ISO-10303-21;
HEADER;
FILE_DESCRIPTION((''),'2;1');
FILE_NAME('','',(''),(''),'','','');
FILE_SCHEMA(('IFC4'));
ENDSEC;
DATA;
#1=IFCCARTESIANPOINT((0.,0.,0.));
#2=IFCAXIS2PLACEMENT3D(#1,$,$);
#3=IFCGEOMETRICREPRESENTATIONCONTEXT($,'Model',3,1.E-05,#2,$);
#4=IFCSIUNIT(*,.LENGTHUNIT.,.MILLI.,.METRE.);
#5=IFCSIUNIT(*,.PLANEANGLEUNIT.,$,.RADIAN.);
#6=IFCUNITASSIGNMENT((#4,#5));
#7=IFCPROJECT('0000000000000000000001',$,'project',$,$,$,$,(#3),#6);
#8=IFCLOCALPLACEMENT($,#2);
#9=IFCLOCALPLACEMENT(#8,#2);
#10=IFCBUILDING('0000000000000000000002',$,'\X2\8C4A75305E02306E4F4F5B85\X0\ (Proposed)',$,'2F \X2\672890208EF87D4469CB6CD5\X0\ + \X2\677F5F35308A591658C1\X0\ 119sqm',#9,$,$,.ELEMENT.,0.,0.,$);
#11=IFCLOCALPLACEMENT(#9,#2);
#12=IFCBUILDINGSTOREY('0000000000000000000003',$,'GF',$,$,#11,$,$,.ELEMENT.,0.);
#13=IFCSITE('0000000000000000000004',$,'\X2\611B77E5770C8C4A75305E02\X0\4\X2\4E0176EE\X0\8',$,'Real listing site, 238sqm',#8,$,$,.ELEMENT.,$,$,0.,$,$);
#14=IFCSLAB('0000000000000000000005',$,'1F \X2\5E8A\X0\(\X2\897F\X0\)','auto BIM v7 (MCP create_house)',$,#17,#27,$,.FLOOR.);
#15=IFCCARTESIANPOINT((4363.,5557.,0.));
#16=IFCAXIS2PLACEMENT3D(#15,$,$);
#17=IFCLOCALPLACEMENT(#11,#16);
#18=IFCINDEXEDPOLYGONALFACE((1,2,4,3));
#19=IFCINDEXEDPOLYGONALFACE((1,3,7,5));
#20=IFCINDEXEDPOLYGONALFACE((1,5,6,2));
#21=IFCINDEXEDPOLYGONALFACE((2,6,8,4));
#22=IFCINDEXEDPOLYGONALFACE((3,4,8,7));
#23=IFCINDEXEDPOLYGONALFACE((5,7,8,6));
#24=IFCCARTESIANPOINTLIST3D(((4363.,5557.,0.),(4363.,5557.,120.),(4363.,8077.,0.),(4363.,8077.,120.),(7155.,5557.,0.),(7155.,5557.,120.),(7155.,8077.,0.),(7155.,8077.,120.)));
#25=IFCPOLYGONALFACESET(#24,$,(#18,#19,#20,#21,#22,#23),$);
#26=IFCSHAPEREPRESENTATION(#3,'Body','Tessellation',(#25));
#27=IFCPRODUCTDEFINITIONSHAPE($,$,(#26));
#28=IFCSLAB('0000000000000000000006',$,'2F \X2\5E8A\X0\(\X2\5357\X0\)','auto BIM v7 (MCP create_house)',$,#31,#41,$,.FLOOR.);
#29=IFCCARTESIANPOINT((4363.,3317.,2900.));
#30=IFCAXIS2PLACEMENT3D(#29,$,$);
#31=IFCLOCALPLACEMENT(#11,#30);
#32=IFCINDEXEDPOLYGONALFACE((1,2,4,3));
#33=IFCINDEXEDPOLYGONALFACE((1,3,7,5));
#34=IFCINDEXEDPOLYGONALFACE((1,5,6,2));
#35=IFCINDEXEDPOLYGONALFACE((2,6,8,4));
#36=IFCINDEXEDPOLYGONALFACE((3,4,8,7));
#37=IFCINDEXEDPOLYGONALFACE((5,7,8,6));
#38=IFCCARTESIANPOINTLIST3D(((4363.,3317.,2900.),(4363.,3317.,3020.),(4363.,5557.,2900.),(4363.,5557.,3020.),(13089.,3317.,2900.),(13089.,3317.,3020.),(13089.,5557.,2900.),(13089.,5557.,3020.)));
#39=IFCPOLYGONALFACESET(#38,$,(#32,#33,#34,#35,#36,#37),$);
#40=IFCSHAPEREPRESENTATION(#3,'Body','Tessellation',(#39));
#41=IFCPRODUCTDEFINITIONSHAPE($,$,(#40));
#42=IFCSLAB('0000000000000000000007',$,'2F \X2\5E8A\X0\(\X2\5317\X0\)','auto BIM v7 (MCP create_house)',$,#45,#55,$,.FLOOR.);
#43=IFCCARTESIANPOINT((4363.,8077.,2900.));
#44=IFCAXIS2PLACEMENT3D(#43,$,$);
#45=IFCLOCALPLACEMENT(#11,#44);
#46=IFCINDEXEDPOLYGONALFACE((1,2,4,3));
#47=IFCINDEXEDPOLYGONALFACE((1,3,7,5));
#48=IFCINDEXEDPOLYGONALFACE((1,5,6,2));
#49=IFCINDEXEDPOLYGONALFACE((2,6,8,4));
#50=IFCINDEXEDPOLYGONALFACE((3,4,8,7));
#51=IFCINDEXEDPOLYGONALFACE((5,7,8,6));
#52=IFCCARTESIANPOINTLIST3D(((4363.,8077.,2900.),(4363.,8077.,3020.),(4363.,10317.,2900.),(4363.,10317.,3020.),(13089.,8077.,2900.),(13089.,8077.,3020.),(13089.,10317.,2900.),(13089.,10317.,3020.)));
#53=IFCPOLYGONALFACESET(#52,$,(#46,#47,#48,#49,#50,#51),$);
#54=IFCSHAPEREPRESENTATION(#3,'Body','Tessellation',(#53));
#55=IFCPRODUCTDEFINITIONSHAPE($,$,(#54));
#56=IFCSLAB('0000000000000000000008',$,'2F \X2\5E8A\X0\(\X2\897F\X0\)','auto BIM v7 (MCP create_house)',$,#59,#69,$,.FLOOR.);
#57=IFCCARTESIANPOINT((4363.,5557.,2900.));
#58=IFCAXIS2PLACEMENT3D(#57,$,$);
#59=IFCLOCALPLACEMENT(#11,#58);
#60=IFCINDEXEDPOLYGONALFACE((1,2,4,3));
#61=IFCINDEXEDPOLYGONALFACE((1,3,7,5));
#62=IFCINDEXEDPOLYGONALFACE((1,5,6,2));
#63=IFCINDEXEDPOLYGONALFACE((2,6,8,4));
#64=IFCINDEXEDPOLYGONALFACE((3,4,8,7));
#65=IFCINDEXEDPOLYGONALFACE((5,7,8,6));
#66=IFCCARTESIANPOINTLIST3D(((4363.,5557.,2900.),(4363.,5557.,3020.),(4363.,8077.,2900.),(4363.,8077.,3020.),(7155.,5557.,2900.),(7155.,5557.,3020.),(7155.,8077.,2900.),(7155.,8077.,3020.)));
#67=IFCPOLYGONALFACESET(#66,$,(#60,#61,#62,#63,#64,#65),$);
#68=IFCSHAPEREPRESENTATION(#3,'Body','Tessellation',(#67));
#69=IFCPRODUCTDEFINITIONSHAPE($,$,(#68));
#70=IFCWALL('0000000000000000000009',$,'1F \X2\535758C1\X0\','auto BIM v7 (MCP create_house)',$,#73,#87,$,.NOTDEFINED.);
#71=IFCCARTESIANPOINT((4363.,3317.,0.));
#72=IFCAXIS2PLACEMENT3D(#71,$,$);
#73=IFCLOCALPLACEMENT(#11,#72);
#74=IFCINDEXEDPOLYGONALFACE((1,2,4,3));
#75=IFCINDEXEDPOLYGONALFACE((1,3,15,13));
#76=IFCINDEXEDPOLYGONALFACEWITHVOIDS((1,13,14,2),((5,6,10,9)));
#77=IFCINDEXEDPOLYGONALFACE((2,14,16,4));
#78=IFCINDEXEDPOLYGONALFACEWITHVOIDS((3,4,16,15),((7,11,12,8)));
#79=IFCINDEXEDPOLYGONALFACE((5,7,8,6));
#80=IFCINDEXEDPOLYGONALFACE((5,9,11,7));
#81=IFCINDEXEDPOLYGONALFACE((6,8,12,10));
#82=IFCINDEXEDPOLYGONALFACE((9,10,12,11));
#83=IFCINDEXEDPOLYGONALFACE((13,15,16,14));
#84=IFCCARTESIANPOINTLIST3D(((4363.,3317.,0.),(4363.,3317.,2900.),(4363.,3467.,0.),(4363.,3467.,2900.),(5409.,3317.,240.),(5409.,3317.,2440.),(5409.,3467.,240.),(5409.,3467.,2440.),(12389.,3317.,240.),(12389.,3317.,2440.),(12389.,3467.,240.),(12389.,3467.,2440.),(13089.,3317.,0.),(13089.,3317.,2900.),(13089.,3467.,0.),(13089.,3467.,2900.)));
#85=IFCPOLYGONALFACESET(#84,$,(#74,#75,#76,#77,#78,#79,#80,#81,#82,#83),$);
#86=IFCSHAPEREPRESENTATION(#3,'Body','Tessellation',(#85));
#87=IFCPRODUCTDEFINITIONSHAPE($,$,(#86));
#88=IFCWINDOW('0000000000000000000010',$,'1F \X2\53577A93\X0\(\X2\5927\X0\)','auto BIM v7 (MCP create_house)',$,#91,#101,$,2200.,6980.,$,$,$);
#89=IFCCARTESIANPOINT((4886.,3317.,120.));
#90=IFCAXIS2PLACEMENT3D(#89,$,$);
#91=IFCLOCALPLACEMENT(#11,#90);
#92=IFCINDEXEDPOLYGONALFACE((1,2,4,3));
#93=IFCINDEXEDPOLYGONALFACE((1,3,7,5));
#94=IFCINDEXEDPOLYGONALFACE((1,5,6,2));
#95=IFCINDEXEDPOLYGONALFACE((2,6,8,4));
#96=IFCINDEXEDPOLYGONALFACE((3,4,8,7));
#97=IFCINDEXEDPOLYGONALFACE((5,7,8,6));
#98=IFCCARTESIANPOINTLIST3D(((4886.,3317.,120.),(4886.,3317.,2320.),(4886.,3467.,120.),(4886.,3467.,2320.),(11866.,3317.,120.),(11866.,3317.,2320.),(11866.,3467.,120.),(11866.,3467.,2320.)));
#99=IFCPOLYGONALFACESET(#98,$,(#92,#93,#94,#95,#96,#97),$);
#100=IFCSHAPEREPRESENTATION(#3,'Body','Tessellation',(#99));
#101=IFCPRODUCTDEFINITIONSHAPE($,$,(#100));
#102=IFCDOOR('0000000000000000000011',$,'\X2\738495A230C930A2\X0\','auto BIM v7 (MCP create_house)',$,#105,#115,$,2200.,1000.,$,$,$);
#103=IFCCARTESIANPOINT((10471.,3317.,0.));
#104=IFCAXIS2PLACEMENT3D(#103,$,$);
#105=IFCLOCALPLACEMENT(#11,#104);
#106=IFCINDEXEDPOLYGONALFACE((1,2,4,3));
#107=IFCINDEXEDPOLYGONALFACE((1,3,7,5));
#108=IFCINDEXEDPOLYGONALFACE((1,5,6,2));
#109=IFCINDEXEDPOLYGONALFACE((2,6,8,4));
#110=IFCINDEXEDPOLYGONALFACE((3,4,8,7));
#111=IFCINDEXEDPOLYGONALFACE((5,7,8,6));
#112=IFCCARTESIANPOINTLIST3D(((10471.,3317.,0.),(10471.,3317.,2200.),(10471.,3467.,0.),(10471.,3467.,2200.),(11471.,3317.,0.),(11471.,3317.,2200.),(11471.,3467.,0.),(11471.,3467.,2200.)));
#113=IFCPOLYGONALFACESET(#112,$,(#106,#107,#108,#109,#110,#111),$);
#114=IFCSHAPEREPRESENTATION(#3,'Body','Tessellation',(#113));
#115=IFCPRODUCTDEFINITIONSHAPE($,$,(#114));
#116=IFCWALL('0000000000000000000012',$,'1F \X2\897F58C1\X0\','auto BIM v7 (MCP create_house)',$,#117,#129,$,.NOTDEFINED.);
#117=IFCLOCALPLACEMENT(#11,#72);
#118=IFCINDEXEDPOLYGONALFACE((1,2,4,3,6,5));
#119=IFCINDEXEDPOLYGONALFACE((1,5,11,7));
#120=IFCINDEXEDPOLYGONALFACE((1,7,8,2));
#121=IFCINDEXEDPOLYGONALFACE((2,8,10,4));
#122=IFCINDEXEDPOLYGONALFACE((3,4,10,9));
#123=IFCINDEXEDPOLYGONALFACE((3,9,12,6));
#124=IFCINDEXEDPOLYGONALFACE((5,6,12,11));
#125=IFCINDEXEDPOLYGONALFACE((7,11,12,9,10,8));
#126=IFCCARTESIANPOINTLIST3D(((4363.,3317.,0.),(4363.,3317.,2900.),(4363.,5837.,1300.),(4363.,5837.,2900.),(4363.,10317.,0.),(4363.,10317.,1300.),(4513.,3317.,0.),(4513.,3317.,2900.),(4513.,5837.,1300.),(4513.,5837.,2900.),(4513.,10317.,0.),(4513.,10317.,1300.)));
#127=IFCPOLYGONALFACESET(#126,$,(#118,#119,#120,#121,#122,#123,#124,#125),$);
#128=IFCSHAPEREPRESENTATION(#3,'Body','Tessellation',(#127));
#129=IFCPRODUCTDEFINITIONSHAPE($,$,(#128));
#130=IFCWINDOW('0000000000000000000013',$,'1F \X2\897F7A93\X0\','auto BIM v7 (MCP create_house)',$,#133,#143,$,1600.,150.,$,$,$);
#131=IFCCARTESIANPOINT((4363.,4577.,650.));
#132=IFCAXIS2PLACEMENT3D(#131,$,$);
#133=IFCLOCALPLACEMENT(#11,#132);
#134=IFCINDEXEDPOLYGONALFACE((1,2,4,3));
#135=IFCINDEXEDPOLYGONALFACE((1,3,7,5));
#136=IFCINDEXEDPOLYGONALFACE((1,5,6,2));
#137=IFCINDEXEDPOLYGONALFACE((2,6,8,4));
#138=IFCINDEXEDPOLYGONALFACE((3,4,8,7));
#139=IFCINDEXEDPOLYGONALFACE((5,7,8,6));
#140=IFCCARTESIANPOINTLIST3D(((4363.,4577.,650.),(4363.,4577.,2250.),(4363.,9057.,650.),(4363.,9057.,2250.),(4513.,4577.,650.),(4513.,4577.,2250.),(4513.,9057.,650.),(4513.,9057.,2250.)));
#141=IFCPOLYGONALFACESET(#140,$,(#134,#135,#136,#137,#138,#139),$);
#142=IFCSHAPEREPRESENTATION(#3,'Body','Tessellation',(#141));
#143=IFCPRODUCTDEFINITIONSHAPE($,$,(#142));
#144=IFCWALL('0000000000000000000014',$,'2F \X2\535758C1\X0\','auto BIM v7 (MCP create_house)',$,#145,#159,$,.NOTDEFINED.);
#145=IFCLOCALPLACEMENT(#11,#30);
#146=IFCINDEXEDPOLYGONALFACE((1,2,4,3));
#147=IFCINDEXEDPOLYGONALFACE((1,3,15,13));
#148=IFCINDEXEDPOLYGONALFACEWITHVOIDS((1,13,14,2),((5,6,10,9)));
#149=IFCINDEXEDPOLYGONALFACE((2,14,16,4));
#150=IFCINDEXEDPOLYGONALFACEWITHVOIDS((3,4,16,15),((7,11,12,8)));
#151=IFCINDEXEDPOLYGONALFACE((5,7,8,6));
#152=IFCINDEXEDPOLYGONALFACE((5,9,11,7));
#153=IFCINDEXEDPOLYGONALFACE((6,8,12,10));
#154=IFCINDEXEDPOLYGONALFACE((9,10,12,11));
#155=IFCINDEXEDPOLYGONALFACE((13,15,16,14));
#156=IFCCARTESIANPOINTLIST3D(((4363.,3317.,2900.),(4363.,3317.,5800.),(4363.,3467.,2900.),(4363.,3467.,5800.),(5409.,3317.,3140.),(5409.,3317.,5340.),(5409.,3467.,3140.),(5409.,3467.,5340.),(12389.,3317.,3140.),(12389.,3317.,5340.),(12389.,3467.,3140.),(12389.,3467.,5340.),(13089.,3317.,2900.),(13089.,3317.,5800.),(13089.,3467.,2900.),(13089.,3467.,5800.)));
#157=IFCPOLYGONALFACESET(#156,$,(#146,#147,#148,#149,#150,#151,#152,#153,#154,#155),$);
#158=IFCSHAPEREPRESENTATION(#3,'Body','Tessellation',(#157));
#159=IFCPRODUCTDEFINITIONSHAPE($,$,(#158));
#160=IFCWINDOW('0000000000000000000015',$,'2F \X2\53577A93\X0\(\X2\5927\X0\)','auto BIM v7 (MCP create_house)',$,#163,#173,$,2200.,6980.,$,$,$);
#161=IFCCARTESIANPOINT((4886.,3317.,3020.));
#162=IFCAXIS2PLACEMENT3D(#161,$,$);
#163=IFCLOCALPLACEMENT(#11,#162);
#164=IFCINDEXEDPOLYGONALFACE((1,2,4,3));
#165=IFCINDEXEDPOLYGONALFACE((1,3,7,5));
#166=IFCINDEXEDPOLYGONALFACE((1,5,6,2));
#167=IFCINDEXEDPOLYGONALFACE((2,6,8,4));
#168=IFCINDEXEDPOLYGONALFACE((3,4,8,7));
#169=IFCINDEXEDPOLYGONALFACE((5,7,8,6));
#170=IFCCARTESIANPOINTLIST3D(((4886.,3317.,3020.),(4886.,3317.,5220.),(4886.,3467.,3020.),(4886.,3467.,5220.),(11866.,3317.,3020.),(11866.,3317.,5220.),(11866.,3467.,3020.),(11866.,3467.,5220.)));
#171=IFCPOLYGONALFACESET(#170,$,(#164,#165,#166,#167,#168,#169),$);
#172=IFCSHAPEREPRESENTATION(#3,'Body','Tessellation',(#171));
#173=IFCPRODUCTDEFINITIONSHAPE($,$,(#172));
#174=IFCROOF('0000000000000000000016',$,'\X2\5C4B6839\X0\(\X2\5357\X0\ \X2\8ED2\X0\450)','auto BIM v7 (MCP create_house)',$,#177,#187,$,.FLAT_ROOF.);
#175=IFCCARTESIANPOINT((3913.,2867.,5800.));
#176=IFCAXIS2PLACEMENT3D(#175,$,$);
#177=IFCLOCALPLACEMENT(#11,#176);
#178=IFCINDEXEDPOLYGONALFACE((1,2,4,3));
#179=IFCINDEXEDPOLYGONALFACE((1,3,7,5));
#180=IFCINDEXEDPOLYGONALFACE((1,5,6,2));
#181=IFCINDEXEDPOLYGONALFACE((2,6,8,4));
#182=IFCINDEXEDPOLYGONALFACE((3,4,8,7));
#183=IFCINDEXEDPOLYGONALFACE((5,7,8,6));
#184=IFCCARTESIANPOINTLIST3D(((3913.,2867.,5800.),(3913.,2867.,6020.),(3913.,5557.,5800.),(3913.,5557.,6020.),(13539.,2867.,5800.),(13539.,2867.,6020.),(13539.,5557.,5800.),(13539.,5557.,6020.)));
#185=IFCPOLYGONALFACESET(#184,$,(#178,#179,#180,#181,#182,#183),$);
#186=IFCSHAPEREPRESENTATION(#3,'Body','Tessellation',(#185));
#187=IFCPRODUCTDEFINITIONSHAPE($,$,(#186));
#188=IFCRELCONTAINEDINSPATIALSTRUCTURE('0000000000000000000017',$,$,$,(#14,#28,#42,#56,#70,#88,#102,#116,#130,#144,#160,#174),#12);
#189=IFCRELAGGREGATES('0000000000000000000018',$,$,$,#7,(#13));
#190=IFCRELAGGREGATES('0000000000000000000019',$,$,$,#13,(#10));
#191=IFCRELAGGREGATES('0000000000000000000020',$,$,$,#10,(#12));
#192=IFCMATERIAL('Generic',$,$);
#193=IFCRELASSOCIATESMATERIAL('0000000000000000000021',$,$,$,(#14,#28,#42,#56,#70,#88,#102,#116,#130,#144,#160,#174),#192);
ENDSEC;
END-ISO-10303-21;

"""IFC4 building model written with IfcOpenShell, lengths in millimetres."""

from ifc_helpers import new_model, si_unit, frame, frame_2d, origin, place, context, project, spatial, rectangle, extrude, material, element, fill, save


model = new_model("IFC4")

# Units and contexts
model_context = context("Model", 3, precision=1e-05, world=origin())
ifc_project = project(units=[si_unit("LENGTHUNIT", "METRE", prefix="MILLI"), si_unit("PLANEANGLEUNIT", "RADIAN")], contexts=[model_context])

# Site, building, storey
site_placement = place(None, origin())
site = spatial("IfcSite", under=ifc_project, at=site_placement, Name="愛知県豊田市4丁目8", ObjectType="Real listing site, 238sqm", CompositionType="ELEMENT", RefElevation=0.0)
building_placement = place(site_placement, origin())
building = spatial("IfcBuilding", under=site, at=building_placement, Name="豊田市の住宅 (Proposed)", ObjectType="2F 木造軸組構法 + 板張り外壁 119sqm", CompositionType="ELEMENT", ElevationOfRefHeight=0.0, ElevationOfTerrain=0.0)
storey_placement = place(building_placement, origin())
storey = spatial("IfcBuildingStorey", under=building, at=storey_placement, Name="GF", CompositionType="ELEMENT", Elevation=0.0)

# Slabs
ifc_material = material(Name="Generic")
slab_1_placement = place(storey_placement, frame((4363.0, 5557.0, 0.0)))
element("IfcSlab", 1, at=slab_1_placement, inside=storey, material=ifc_material, Name="1F 床(西)", Description="auto BIM v7 (MCP create_house)", PredefinedType="FLOOR", context=model_context, shape_type="SweptSolid", body=[
    extrude(rectangle(XDim=2792.0, YDim=2520.0, at=frame_2d((1396.0, 1260.0))), frame((4363.0, 5557.0, 0.0)), (0.0, 0.0, 1.0), 120.0),
])
slab_2_placement = place(storey_placement, frame((4363.0, 3317.0, 2900.0)))
element("IfcSlab", 2, at=slab_2_placement, inside=storey, material=ifc_material, Name="2F 床(南)", Description="auto BIM v7 (MCP create_house)", PredefinedType="FLOOR", context=model_context, shape_type="SweptSolid", body=[
    extrude(rectangle(XDim=8726.0, YDim=2240.0, at=frame_2d((4363.0, 1120.0))), frame((4363.0, 3317.0, 2900.0)), (0.0, 0.0, 1.0), 120.0),
])
slab_3_placement = place(storey_placement, frame((4363.0, 8077.0, 2900.0)))
element("IfcSlab", 3, at=slab_3_placement, inside=storey, material=ifc_material, Name="2F 床(北)", Description="auto BIM v7 (MCP create_house)", PredefinedType="FLOOR", context=model_context, shape_type="SweptSolid", body=[
    extrude(rectangle(XDim=8726.0, YDim=2240.0, at=frame_2d((4363.0, 1120.0))), frame((4363.0, 8077.0, 2900.0)), (0.0, 0.0, 1.0), 120.0),
])
slab_4_placement = place(storey_placement, frame((4363.0, 5557.0, 2900.0)))
element("IfcSlab", 4, at=slab_4_placement, inside=storey, material=ifc_material, Name="2F 床(西)", Description="auto BIM v7 (MCP create_house)", PredefinedType="FLOOR", context=model_context, shape_type="SweptSolid", body=[
    extrude(rectangle(XDim=2792.0, YDim=2520.0, at=frame_2d((1396.0, 1260.0))), frame((4363.0, 5557.0, 2900.0)), (0.0, 0.0, 1.0), 120.0),
])

# Wall, openings, window, door
wall_1_placement = place(storey_placement, frame((4363.0, 3317.0, 0.0)))
wall_1 = element("IfcWall", 5, at=wall_1_placement, inside=storey, material=ifc_material, Name="1F 南壁", Description="auto BIM v7 (MCP create_house)", PredefinedType="NOTDEFINED", context=model_context, shape_type="SweptSolid", body=[
    extrude(rectangle(XDim=8726.0, YDim=150.0, at=frame_2d((4363.0, 75.0))), frame((4363.0, 3317.0, 0.0)), (0.0, 0.0, 1.0), 2900.0),
])
opening_1_placement = place(storey_placement, frame((4886.0, 3317.0, 120.0)))
opening_1 = element("IfcOpeningElement", 6, at=opening_1_placement, cuts=wall_1, PredefinedType="NOTDEFINED", context=model_context, shape_type="SweptSolid", body=[
    extrude(rectangle(XDim=6980.0, YDim=150.0, at=frame_2d((3490.0, 75.0))), frame((4886.0, 3317.0, 120.0)), (0.0, 0.0, 1.0), 2200.0),
])
opening_2_placement = place(storey_placement, frame((10471.0, 3317.0, 0.0)))
opening_2 = element("IfcOpeningElement", 7, at=opening_2_placement, cuts=wall_1, PredefinedType="NOTDEFINED", context=model_context, shape_type="SweptSolid", body=[
    extrude(rectangle(XDim=1000.0, YDim=150.0, at=frame_2d((500.0, 75.0))), frame((10471.0, 3317.0, 0.0)), (0.0, 0.0, 1.0), 2200.0),
])
window_1_placement = place(storey_placement, frame((4886.0, 3317.0, 120.0)))
window_1 = element("IfcWindow", 8, at=window_1_placement, inside=storey, material=ifc_material, Name="1F 南窓(大)", Description="auto BIM v7 (MCP create_house)", OverallHeight=2200.0, OverallWidth=6980.0, context=model_context, shape_type="SweptSolid", body=[
    extrude(rectangle(XDim=6980.0, YDim=150.0, at=frame_2d((3490.0, 75.0))), frame((4886.0, 3317.0, 120.0)), (0.0, 0.0, 1.0), 2200.0),
])
fill(opening_1, window_1)
door_placement = place(storey_placement, frame((10471.0, 3317.0, 0.0)))
door = element("IfcDoor", 9, at=door_placement, inside=storey, material=ifc_material, Name="玄関ドア", Description="auto BIM v7 (MCP create_house)", OverallHeight=2200.0, OverallWidth=1000.0, context=model_context, shape_type="SweptSolid", body=[
    extrude(rectangle(XDim=1000.0, YDim=150.0, at=frame_2d((500.0, 75.0))), frame((10471.0, 3317.0, 0.0)), (0.0, 0.0, 1.0), 2200.0),
])
fill(opening_2, door)

# Walls, openings, windows
wall_2_placement = place(storey_placement, frame((4363.0, 3317.0, 0.0)))
wall_2 = element("IfcWall", 10, at=wall_2_placement, inside=storey, material=ifc_material, Name="1F 西壁", Description="auto BIM v7 (MCP create_house)", PredefinedType="NOTDEFINED", context=model_context, shape_type="SweptSolid", body=[
    extrude(rectangle(XDim=150.0, YDim=7000.0, at=frame_2d((75.0, 3500.0))), frame((4363.0, 3317.0, 0.0)), (0.0, 0.0, 1.0), 2900.0),
])
opening_3_placement = place(storey_placement, frame((4363.0, 4577.0, 650.0)))
opening_3 = element("IfcOpeningElement", 11, at=opening_3_placement, cuts=wall_2, PredefinedType="NOTDEFINED", context=model_context, shape_type="SweptSolid", body=[
    extrude(rectangle(XDim=150.0, YDim=4480.0, at=frame_2d((75.0, 2240.0))), frame((4363.0, 4577.0, 650.0)), (0.0, 0.0, 1.0), 1600.0),
])
window_2_placement = place(storey_placement, frame((4363.0, 4577.0, 650.0)))
window_2 = element("IfcWindow", 12, at=window_2_placement, inside=storey, material=ifc_material, Name="1F 西窓", Description="auto BIM v7 (MCP create_house)", OverallHeight=1600.0, OverallWidth=150.0, context=model_context, shape_type="SweptSolid", body=[
    extrude(rectangle(XDim=150.0, YDim=4480.0, at=frame_2d((75.0, 2240.0))), frame((4363.0, 4577.0, 650.0)), (0.0, 0.0, 1.0), 1600.0),
])
fill(opening_3, window_2)
wall_3_placement = place(storey_placement, frame((4363.0, 3317.0, 2900.0)))
wall_3 = element("IfcWall", 13, at=wall_3_placement, inside=storey, material=ifc_material, Name="2F 南壁", Description="auto BIM v7 (MCP create_house)", PredefinedType="NOTDEFINED", context=model_context, shape_type="SweptSolid", body=[
    extrude(rectangle(XDim=8726.0, YDim=150.0, at=frame_2d((4363.0, 75.0))), frame((4363.0, 3317.0, 2900.0)), (0.0, 0.0, 1.0), 2900.0),
])
opening_4_placement = place(storey_placement, frame((4886.0, 3317.0, 3020.0)))
opening_4 = element("IfcOpeningElement", 14, at=opening_4_placement, cuts=wall_3, PredefinedType="NOTDEFINED", context=model_context, shape_type="SweptSolid", body=[
    extrude(rectangle(XDim=6980.0, YDim=150.0, at=frame_2d((3490.0, 75.0))), frame((4886.0, 3317.0, 3020.0)), (0.0, 0.0, 1.0), 2200.0),
])
window_3_placement = place(storey_placement, frame((4886.0, 3317.0, 3020.0)))
window_3 = element("IfcWindow", 15, at=window_3_placement, inside=storey, material=ifc_material, Name="2F 南窓(大)", Description="auto BIM v7 (MCP create_house)", OverallHeight=2200.0, OverallWidth=6980.0, context=model_context, shape_type="SweptSolid", body=[
    extrude(rectangle(XDim=6980.0, YDim=150.0, at=frame_2d((3490.0, 75.0))), frame((4886.0, 3317.0, 3020.0)), (0.0, 0.0, 1.0), 2200.0),
])
fill(opening_4, window_3)

# Roof
roof_1_placement = place(storey_placement, frame((3913.0, 2867.0, 5800.0)))
element("IfcRoof", 16, at=roof_1_placement, inside=storey, material=ifc_material, Name="屋根(南 軒450)", Description="auto BIM v7 (MCP create_house)", PredefinedType="FLAT_ROOF", context=model_context, shape_type="SweptSolid", body=[
    extrude(rectangle(XDim=9626.0, YDim=2690.0, at=frame_2d((4813.0, 1345.0))), frame((3913.0, 2867.0, 5800.0)), (0.0, 0.0, 1.0), 220.0),
])

save(model, "model.ifc")
